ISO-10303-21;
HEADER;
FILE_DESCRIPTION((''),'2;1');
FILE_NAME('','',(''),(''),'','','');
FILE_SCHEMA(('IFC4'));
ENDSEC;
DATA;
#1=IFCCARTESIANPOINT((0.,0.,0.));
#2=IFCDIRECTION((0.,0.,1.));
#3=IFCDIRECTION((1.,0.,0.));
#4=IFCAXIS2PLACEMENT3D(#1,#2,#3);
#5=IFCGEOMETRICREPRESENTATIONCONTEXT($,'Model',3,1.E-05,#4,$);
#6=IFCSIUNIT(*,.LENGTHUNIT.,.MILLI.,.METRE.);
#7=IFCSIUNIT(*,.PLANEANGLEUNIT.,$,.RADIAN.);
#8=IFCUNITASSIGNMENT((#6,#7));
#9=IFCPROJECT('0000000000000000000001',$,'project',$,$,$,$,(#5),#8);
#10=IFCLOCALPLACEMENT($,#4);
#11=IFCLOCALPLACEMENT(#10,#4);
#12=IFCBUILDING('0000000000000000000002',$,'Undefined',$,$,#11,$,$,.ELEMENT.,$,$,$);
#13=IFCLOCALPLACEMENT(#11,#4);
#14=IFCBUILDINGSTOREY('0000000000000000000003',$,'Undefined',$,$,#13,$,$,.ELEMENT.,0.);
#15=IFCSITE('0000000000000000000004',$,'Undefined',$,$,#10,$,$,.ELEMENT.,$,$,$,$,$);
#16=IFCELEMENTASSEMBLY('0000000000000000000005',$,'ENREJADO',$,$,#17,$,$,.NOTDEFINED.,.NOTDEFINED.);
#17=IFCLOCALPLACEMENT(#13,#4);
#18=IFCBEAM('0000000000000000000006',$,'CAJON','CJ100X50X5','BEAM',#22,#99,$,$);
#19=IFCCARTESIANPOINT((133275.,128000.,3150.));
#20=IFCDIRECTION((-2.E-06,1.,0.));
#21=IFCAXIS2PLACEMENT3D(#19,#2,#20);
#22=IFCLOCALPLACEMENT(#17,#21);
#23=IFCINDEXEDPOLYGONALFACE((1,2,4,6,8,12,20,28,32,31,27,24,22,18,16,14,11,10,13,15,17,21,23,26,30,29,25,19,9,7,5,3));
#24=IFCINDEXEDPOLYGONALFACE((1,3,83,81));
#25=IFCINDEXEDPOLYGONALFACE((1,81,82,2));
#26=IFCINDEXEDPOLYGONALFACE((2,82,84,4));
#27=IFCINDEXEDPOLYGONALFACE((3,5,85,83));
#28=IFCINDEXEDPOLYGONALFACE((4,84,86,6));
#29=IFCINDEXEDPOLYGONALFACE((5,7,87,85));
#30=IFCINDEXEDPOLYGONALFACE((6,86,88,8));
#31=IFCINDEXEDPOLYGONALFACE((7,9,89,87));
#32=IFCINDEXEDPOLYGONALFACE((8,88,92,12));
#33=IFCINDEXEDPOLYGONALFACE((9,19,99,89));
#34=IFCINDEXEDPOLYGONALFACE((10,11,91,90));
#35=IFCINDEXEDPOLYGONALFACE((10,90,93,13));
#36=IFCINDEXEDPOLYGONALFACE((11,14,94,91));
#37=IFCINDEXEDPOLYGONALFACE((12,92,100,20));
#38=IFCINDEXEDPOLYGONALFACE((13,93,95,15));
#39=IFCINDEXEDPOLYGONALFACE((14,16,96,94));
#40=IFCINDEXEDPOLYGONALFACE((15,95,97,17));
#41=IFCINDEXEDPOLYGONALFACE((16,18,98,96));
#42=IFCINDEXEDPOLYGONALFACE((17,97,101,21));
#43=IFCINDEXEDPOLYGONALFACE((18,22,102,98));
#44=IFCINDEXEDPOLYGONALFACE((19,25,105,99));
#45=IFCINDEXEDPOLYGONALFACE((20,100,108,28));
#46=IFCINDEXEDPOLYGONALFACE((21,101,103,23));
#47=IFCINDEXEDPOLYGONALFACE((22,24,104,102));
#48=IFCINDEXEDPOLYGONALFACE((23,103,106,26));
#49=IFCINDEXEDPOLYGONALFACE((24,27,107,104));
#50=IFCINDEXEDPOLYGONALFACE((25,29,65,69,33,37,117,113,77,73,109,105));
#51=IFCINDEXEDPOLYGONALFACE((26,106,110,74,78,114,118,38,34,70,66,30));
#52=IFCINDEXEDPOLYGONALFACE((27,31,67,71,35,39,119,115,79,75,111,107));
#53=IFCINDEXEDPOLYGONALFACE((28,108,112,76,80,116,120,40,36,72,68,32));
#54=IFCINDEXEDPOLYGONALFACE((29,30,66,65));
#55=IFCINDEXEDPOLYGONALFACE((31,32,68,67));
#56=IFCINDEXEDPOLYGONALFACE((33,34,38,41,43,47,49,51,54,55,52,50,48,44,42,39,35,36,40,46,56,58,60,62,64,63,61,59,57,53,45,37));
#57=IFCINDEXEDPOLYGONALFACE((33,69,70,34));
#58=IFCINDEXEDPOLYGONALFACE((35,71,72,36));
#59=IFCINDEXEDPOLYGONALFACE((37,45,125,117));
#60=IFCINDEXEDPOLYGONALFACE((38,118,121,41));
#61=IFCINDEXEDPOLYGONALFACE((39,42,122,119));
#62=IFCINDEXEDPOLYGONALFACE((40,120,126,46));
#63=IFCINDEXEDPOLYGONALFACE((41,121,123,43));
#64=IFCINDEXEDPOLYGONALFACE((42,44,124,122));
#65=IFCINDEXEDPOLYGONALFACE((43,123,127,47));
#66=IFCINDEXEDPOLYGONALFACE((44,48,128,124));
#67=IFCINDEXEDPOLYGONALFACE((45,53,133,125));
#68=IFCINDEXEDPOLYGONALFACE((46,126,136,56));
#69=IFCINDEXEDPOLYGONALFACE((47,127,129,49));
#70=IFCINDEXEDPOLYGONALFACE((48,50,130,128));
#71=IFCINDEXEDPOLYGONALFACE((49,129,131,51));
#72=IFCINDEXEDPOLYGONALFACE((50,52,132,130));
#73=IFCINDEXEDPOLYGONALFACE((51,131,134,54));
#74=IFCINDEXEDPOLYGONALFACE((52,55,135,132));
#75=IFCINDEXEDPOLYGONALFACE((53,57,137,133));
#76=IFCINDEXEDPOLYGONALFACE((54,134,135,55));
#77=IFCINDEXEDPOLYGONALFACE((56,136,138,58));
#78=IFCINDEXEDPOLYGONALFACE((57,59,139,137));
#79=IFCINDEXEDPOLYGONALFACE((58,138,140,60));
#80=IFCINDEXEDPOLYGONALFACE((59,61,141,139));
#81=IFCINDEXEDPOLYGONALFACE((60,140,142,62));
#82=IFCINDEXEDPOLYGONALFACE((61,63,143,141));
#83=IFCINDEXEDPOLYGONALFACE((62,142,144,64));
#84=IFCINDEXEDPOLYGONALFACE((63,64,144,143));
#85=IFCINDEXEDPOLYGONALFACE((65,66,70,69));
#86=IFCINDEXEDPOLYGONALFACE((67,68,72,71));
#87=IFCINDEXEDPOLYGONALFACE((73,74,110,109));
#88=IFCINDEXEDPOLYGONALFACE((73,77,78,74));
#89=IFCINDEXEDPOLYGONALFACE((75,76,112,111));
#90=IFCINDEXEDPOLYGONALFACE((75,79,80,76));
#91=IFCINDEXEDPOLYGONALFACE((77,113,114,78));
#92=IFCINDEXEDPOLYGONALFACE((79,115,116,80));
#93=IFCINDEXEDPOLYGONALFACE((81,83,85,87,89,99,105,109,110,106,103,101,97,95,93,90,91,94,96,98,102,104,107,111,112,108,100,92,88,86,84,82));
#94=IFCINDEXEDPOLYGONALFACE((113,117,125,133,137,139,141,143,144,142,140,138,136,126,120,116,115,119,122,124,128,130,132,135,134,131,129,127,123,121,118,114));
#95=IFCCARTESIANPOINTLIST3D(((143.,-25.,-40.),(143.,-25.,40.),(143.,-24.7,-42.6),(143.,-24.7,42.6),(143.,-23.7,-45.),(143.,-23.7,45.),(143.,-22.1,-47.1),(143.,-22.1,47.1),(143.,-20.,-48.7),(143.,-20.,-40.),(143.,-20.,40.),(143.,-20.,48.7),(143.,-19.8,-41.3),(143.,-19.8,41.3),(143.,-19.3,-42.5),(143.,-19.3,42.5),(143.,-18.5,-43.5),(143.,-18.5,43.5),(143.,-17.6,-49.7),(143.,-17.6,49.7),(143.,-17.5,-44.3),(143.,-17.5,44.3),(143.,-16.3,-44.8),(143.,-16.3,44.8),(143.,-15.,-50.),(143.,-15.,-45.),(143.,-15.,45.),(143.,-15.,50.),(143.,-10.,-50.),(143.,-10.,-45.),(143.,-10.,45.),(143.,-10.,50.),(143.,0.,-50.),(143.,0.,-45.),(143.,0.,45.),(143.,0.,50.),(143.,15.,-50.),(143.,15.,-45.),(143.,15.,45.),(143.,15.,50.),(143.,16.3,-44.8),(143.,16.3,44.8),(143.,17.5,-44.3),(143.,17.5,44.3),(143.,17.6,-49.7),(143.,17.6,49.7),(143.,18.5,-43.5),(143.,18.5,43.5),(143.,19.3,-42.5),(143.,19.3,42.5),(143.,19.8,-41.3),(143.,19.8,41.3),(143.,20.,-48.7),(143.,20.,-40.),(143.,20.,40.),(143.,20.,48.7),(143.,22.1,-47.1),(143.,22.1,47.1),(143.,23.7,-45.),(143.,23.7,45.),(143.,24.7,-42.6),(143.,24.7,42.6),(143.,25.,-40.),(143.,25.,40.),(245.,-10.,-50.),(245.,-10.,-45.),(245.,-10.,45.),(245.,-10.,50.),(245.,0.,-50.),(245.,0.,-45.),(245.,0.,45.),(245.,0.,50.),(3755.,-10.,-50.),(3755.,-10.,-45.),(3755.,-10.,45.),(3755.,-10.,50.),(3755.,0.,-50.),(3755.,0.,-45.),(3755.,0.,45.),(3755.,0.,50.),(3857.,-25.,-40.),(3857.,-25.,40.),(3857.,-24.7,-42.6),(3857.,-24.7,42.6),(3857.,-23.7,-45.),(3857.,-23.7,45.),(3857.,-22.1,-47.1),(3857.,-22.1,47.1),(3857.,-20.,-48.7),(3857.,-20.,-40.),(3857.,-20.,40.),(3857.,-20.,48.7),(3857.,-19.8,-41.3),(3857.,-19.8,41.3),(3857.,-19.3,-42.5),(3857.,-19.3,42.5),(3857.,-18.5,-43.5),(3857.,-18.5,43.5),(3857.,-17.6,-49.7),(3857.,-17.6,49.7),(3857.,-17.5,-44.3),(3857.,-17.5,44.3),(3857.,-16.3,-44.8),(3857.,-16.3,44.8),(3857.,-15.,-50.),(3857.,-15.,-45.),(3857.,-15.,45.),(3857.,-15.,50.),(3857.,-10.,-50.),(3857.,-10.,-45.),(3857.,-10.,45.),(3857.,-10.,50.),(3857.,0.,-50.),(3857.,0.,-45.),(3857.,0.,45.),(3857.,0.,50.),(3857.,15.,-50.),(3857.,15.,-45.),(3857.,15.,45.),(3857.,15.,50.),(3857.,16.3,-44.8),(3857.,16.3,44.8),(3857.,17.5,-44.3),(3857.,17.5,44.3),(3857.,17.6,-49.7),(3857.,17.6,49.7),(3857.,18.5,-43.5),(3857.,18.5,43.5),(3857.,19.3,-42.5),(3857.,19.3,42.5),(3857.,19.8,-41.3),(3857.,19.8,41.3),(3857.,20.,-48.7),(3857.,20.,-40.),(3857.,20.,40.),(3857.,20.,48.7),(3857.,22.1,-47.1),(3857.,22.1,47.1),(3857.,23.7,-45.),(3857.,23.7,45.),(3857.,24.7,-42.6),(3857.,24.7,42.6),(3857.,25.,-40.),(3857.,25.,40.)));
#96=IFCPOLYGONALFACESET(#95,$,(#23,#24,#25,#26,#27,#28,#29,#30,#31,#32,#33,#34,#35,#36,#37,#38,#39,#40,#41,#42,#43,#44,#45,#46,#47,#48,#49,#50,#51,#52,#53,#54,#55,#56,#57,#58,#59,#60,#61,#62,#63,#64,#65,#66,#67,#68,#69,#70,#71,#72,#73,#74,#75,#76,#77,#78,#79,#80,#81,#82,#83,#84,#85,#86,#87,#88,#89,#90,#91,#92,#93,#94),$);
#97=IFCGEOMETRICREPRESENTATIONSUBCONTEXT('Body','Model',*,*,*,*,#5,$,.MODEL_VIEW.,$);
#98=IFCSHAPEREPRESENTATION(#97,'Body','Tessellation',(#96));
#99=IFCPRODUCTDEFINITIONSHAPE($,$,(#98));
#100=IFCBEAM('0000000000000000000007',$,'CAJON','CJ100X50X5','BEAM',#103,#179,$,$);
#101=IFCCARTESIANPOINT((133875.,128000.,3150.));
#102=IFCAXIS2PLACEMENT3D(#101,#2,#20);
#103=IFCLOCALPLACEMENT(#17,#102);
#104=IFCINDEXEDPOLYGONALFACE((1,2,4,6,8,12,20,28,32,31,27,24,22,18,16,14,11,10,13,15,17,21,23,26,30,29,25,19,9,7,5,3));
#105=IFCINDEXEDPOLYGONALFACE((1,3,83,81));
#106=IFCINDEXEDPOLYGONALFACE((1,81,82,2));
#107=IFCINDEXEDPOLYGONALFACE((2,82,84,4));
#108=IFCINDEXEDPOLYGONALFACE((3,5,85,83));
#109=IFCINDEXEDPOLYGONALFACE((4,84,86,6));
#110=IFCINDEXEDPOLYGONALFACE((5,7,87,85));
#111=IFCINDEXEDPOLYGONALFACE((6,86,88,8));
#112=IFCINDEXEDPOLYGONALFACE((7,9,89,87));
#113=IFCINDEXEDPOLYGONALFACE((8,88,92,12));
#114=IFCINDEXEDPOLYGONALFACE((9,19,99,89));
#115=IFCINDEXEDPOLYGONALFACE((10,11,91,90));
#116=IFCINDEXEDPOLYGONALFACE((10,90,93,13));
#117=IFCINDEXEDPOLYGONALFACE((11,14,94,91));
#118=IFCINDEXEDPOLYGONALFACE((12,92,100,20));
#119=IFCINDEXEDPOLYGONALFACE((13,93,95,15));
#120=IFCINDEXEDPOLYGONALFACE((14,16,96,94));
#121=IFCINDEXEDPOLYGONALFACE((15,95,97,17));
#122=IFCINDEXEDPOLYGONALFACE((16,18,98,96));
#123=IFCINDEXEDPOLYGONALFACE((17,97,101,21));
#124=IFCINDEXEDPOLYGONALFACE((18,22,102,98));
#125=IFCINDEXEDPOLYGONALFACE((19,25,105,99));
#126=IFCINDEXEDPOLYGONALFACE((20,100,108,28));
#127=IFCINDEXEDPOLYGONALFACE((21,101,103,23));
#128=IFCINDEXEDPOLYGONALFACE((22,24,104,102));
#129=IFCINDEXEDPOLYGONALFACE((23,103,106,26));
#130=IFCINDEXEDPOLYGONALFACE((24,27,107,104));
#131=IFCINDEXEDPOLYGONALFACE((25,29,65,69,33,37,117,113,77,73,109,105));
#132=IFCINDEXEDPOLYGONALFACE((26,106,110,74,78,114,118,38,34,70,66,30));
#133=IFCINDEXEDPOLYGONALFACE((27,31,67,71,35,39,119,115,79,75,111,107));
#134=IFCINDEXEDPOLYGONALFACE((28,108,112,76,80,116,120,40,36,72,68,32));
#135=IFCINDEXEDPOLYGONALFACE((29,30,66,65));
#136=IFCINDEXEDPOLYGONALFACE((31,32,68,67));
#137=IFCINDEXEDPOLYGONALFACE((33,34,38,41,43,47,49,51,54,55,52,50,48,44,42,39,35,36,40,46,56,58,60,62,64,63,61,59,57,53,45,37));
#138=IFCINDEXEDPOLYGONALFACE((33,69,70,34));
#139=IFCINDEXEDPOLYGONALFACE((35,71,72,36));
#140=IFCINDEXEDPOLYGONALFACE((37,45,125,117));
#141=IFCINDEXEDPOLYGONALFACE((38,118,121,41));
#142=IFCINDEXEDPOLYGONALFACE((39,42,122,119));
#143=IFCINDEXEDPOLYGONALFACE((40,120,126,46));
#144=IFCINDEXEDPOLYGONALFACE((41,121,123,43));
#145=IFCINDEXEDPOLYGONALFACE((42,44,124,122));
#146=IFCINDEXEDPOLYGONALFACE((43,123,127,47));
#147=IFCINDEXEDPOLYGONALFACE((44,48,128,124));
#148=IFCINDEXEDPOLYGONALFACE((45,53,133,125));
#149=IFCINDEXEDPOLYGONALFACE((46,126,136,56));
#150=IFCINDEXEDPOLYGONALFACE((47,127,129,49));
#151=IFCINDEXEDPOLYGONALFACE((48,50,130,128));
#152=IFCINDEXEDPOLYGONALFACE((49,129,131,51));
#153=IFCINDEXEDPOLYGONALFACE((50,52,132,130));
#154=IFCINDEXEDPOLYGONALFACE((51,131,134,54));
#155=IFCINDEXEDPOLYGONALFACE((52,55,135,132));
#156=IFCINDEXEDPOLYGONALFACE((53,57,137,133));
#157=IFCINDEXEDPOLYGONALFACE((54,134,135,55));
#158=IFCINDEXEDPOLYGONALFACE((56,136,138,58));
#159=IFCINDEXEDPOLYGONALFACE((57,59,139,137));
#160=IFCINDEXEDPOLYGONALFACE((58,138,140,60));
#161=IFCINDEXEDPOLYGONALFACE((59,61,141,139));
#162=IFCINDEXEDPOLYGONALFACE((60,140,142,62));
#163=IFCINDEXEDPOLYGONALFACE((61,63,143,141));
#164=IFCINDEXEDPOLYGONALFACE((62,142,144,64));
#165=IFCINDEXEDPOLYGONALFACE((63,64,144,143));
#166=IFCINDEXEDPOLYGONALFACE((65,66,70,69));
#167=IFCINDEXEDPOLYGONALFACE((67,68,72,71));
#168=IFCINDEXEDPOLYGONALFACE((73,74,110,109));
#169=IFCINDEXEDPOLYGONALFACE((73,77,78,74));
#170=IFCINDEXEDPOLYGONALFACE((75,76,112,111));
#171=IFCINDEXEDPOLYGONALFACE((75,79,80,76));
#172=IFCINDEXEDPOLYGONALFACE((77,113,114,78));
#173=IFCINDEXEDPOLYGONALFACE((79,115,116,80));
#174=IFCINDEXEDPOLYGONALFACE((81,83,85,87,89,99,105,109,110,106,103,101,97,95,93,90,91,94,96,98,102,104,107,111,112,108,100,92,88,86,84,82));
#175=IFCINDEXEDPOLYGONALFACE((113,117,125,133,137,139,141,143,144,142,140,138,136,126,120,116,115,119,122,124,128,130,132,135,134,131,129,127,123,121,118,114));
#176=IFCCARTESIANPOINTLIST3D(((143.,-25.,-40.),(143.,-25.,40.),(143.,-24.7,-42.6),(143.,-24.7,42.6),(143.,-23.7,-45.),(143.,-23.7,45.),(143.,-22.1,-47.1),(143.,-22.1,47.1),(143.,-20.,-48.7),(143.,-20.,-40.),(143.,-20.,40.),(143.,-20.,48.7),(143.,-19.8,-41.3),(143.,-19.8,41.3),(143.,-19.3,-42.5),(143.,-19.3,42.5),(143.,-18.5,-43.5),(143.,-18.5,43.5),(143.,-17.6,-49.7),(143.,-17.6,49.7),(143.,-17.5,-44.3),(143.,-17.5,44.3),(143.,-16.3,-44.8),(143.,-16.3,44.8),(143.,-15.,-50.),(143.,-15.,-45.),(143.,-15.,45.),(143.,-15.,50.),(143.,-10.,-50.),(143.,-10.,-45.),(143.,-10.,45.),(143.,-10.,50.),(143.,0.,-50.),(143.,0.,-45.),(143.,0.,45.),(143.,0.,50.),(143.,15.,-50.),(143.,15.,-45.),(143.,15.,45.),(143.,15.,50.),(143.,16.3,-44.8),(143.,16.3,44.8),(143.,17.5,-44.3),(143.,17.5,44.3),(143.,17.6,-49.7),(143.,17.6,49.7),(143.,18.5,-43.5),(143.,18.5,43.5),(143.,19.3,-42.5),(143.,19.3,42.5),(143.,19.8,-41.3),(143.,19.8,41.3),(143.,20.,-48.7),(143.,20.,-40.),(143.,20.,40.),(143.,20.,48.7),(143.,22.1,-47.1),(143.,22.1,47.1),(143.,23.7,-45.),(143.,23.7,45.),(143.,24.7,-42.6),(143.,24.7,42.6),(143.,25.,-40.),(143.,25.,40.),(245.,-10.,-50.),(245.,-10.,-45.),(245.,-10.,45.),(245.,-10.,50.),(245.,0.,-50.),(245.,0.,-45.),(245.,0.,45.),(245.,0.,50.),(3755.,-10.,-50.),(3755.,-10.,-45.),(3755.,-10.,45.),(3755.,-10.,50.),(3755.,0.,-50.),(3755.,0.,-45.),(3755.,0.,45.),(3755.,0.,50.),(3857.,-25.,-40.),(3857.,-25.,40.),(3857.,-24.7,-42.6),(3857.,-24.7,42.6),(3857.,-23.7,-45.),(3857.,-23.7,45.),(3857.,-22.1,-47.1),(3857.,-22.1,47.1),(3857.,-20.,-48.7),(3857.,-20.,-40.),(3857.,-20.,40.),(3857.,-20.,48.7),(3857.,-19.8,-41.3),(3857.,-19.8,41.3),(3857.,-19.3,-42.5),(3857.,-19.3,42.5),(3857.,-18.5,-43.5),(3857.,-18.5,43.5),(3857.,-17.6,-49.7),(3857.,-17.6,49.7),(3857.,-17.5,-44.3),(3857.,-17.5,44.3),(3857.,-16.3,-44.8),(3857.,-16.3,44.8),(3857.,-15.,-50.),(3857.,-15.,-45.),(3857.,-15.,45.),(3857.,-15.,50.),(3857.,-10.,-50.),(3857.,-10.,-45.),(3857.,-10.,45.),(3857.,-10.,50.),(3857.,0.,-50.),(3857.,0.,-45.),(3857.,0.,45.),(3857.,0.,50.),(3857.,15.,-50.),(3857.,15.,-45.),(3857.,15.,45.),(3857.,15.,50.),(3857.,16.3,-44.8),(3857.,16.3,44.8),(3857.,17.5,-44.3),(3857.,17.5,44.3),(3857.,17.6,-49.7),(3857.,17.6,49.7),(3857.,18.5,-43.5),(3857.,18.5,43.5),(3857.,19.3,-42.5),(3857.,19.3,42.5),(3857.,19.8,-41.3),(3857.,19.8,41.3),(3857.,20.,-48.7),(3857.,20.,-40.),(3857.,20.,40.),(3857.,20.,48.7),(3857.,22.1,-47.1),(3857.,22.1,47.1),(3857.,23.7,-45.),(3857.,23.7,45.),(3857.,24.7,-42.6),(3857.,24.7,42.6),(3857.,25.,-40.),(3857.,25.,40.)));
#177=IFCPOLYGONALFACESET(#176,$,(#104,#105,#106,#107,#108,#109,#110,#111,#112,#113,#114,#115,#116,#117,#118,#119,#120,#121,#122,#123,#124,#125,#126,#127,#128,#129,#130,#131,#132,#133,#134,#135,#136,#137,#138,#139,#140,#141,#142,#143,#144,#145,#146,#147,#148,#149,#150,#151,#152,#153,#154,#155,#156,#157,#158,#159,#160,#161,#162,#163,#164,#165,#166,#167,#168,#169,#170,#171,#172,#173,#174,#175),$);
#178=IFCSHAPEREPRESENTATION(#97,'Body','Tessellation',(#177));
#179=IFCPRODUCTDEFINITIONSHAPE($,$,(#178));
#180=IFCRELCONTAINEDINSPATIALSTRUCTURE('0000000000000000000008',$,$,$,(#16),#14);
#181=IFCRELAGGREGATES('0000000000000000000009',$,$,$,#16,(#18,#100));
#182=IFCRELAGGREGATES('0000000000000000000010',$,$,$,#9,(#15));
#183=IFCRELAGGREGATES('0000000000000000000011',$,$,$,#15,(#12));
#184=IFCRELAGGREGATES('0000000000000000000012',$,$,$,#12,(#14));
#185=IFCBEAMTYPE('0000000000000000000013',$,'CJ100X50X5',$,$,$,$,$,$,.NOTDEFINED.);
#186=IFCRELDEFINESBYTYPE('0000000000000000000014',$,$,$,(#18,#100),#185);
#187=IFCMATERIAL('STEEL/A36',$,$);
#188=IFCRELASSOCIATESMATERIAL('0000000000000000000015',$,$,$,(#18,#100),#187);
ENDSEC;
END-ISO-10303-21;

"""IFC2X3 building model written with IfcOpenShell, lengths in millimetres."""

from ifc_helpers import new_model, si_unit, frame, origin_with_axes, origin_2d_with_axis, place, context, subcontext, project, spatial, rectangle, hollow_rectangle, extrude, boolean, halfspace, material, type_object, element, aggregate, save


model = new_model("IFC2X3")

# Units and contexts
model_context = context("Model", 3, precision=1e-05, world=origin_with_axes())
body_context = subcontext(model_context, "Body", "Model", "MODEL_VIEW")
ifc_project = project(units=[si_unit("LENGTHUNIT", "METRE", prefix="MILLI"), si_unit("PLANEANGLEUNIT", "RADIAN")], contexts=[model_context])

# Site, building, storey
site_placement = place(None, origin_with_axes())
site = spatial("IfcSite", under=ifc_project, at=site_placement, Name="Undefined", CompositionType="ELEMENT")
building_placement = place(site_placement, origin_with_axes())
building = spatial("IfcBuilding", under=site, at=building_placement, Name="Undefined", CompositionType="ELEMENT")
storey_placement = place(building_placement, origin_with_axes())
storey = spatial("IfcBuildingStorey", under=building, at=storey_placement, Name="Undefined", CompositionType="ELEMENT", Elevation=0.0)

# Shared definitions
ifc_material_1 = material(Name="STEEL/A36")

# Element assembly, beams
assembly_1_placement = place(storey_placement, origin_with_axes())
assembly_1 = element("IfcElementAssembly", 1, at=assembly_1_placement, inside=storey, Name="ENREJADO", AssemblyPlace="NOTDEFINED", PredefinedType="NOTDEFINED")
beam_type_1 = type_object("IfcBeamType", Name="CJ100X50X5", PredefinedType="NOTDEFINED")
beam_1_placement = place(assembly_1_placement, frame((133275.0, 128000.0, 3150.0), z_axis=(0.0, 0.0, 1.0), x_axis=(-0.000002, 1.0, 0.0)))
beam_1 = element("IfcBeam", 2, at=beam_1_placement, type_object=beam_type_1, material=ifc_material_1, Name="CAJON", Description="CJ100X50X5", ObjectType="BEAM", context=body_context, shape_type="CSG", body=[
    boolean("DIFFERENCE", boolean("DIFFERENCE", boolean("DIFFERENCE", boolean("DIFFERENCE", extrude(hollow_rectangle(XDim=50.0, YDim=100.0, WallThickness=5.0, InnerFilletRadius=5.0, OuterFilletRadius=10.0, at=origin_2d_with_axis()), frame((4000.0, 0.0, 0.0), z_axis=(-1.0, 0.0, 0.0), x_axis=(0.0, -1.0, 0.0)), (0.0, 0.0, 1.0), 4000.0), extrude(rectangle(XDim=10.0, YDim=104.0, at=origin_2d_with_axis()), frame((3755.0, -5.0, 0.0), z_axis=(1.0, 0.0, 0.0), x_axis=(0.0, 1.0, 0.0)), (0.0, 0.0, 1.0), 120.0)), extrude(rectangle(XDim=10.0, YDim=104.0, at=origin_2d_with_axis()), frame((245.0, -5.0, 0.0), z_axis=(-1.0, 0.000003, 0.0), x_axis=(0.000002, 1.0, 0.0)), (0.0, 0.0, 1.0), 120.0)), halfspace(frame((3857.0, 200.0, 50.0), z_axis=(-1.0, 0.0, 0.0), x_axis=(0.0, -1.0, 0.0)), True)), halfspace(frame((143.0, 200.0, -50.0), z_axis=(1.0, -0.000003, 0.0), x_axis=(-0.000002, -1.0, 0.0)), True)),
])
beam_2_placement = place(assembly_1_placement, frame((133875.0, 128000.0, 3150.0), z_axis=(0.0, 0.0, 1.0), x_axis=(-0.000002, 1.0, 0.0)))
beam_2 = element("IfcBeam", 3, at=beam_2_placement, type_object=beam_type_1, material=ifc_material_1, Name="CAJON", Description="CJ100X50X5", ObjectType="BEAM", context=body_context, shape_type="CSG", body=[
    boolean("DIFFERENCE", boolean("DIFFERENCE", boolean("DIFFERENCE", boolean("DIFFERENCE", extrude(hollow_rectangle(XDim=50.0, YDim=100.0, WallThickness=5.0, InnerFilletRadius=5.0, OuterFilletRadius=10.0, at=origin_2d_with_axis()), frame((4000.0, 0.0, 0.0), z_axis=(-1.0, 0.0, 0.0), x_axis=(0.0, -1.0, 0.0)), (0.0, 0.0, 1.0), 4000.0), extrude(rectangle(XDim=10.0, YDim=104.0, at=origin_2d_with_axis()), frame((3755.0, -5.0, 0.0), z_axis=(1.0, 0.0, 0.0), x_axis=(0.0, 1.0, 0.0)), (0.0, 0.0, 1.0), 120.0)), extrude(rectangle(XDim=10.0, YDim=104.0, at=origin_2d_with_axis()), frame((245.0, -5.0, 0.0), z_axis=(-1.0, 0.000003, 0.0), x_axis=(0.000002, 1.0, 0.0)), (0.0, 0.0, 1.0), 120.0)), halfspace(frame((3857.0, 200.0, 50.0), z_axis=(-1.0, 0.0, 0.0), x_axis=(0.0, -1.0, 0.0)), True)), halfspace(frame((143.0, 200.0, -50.0), z_axis=(1.0, -0.000003, 0.0), x_axis=(-0.000002, -1.0, 0.0)), True)),
])

aggregate(assembly_1, [beam_1, beam_2])

save(model, "model.ifc")
